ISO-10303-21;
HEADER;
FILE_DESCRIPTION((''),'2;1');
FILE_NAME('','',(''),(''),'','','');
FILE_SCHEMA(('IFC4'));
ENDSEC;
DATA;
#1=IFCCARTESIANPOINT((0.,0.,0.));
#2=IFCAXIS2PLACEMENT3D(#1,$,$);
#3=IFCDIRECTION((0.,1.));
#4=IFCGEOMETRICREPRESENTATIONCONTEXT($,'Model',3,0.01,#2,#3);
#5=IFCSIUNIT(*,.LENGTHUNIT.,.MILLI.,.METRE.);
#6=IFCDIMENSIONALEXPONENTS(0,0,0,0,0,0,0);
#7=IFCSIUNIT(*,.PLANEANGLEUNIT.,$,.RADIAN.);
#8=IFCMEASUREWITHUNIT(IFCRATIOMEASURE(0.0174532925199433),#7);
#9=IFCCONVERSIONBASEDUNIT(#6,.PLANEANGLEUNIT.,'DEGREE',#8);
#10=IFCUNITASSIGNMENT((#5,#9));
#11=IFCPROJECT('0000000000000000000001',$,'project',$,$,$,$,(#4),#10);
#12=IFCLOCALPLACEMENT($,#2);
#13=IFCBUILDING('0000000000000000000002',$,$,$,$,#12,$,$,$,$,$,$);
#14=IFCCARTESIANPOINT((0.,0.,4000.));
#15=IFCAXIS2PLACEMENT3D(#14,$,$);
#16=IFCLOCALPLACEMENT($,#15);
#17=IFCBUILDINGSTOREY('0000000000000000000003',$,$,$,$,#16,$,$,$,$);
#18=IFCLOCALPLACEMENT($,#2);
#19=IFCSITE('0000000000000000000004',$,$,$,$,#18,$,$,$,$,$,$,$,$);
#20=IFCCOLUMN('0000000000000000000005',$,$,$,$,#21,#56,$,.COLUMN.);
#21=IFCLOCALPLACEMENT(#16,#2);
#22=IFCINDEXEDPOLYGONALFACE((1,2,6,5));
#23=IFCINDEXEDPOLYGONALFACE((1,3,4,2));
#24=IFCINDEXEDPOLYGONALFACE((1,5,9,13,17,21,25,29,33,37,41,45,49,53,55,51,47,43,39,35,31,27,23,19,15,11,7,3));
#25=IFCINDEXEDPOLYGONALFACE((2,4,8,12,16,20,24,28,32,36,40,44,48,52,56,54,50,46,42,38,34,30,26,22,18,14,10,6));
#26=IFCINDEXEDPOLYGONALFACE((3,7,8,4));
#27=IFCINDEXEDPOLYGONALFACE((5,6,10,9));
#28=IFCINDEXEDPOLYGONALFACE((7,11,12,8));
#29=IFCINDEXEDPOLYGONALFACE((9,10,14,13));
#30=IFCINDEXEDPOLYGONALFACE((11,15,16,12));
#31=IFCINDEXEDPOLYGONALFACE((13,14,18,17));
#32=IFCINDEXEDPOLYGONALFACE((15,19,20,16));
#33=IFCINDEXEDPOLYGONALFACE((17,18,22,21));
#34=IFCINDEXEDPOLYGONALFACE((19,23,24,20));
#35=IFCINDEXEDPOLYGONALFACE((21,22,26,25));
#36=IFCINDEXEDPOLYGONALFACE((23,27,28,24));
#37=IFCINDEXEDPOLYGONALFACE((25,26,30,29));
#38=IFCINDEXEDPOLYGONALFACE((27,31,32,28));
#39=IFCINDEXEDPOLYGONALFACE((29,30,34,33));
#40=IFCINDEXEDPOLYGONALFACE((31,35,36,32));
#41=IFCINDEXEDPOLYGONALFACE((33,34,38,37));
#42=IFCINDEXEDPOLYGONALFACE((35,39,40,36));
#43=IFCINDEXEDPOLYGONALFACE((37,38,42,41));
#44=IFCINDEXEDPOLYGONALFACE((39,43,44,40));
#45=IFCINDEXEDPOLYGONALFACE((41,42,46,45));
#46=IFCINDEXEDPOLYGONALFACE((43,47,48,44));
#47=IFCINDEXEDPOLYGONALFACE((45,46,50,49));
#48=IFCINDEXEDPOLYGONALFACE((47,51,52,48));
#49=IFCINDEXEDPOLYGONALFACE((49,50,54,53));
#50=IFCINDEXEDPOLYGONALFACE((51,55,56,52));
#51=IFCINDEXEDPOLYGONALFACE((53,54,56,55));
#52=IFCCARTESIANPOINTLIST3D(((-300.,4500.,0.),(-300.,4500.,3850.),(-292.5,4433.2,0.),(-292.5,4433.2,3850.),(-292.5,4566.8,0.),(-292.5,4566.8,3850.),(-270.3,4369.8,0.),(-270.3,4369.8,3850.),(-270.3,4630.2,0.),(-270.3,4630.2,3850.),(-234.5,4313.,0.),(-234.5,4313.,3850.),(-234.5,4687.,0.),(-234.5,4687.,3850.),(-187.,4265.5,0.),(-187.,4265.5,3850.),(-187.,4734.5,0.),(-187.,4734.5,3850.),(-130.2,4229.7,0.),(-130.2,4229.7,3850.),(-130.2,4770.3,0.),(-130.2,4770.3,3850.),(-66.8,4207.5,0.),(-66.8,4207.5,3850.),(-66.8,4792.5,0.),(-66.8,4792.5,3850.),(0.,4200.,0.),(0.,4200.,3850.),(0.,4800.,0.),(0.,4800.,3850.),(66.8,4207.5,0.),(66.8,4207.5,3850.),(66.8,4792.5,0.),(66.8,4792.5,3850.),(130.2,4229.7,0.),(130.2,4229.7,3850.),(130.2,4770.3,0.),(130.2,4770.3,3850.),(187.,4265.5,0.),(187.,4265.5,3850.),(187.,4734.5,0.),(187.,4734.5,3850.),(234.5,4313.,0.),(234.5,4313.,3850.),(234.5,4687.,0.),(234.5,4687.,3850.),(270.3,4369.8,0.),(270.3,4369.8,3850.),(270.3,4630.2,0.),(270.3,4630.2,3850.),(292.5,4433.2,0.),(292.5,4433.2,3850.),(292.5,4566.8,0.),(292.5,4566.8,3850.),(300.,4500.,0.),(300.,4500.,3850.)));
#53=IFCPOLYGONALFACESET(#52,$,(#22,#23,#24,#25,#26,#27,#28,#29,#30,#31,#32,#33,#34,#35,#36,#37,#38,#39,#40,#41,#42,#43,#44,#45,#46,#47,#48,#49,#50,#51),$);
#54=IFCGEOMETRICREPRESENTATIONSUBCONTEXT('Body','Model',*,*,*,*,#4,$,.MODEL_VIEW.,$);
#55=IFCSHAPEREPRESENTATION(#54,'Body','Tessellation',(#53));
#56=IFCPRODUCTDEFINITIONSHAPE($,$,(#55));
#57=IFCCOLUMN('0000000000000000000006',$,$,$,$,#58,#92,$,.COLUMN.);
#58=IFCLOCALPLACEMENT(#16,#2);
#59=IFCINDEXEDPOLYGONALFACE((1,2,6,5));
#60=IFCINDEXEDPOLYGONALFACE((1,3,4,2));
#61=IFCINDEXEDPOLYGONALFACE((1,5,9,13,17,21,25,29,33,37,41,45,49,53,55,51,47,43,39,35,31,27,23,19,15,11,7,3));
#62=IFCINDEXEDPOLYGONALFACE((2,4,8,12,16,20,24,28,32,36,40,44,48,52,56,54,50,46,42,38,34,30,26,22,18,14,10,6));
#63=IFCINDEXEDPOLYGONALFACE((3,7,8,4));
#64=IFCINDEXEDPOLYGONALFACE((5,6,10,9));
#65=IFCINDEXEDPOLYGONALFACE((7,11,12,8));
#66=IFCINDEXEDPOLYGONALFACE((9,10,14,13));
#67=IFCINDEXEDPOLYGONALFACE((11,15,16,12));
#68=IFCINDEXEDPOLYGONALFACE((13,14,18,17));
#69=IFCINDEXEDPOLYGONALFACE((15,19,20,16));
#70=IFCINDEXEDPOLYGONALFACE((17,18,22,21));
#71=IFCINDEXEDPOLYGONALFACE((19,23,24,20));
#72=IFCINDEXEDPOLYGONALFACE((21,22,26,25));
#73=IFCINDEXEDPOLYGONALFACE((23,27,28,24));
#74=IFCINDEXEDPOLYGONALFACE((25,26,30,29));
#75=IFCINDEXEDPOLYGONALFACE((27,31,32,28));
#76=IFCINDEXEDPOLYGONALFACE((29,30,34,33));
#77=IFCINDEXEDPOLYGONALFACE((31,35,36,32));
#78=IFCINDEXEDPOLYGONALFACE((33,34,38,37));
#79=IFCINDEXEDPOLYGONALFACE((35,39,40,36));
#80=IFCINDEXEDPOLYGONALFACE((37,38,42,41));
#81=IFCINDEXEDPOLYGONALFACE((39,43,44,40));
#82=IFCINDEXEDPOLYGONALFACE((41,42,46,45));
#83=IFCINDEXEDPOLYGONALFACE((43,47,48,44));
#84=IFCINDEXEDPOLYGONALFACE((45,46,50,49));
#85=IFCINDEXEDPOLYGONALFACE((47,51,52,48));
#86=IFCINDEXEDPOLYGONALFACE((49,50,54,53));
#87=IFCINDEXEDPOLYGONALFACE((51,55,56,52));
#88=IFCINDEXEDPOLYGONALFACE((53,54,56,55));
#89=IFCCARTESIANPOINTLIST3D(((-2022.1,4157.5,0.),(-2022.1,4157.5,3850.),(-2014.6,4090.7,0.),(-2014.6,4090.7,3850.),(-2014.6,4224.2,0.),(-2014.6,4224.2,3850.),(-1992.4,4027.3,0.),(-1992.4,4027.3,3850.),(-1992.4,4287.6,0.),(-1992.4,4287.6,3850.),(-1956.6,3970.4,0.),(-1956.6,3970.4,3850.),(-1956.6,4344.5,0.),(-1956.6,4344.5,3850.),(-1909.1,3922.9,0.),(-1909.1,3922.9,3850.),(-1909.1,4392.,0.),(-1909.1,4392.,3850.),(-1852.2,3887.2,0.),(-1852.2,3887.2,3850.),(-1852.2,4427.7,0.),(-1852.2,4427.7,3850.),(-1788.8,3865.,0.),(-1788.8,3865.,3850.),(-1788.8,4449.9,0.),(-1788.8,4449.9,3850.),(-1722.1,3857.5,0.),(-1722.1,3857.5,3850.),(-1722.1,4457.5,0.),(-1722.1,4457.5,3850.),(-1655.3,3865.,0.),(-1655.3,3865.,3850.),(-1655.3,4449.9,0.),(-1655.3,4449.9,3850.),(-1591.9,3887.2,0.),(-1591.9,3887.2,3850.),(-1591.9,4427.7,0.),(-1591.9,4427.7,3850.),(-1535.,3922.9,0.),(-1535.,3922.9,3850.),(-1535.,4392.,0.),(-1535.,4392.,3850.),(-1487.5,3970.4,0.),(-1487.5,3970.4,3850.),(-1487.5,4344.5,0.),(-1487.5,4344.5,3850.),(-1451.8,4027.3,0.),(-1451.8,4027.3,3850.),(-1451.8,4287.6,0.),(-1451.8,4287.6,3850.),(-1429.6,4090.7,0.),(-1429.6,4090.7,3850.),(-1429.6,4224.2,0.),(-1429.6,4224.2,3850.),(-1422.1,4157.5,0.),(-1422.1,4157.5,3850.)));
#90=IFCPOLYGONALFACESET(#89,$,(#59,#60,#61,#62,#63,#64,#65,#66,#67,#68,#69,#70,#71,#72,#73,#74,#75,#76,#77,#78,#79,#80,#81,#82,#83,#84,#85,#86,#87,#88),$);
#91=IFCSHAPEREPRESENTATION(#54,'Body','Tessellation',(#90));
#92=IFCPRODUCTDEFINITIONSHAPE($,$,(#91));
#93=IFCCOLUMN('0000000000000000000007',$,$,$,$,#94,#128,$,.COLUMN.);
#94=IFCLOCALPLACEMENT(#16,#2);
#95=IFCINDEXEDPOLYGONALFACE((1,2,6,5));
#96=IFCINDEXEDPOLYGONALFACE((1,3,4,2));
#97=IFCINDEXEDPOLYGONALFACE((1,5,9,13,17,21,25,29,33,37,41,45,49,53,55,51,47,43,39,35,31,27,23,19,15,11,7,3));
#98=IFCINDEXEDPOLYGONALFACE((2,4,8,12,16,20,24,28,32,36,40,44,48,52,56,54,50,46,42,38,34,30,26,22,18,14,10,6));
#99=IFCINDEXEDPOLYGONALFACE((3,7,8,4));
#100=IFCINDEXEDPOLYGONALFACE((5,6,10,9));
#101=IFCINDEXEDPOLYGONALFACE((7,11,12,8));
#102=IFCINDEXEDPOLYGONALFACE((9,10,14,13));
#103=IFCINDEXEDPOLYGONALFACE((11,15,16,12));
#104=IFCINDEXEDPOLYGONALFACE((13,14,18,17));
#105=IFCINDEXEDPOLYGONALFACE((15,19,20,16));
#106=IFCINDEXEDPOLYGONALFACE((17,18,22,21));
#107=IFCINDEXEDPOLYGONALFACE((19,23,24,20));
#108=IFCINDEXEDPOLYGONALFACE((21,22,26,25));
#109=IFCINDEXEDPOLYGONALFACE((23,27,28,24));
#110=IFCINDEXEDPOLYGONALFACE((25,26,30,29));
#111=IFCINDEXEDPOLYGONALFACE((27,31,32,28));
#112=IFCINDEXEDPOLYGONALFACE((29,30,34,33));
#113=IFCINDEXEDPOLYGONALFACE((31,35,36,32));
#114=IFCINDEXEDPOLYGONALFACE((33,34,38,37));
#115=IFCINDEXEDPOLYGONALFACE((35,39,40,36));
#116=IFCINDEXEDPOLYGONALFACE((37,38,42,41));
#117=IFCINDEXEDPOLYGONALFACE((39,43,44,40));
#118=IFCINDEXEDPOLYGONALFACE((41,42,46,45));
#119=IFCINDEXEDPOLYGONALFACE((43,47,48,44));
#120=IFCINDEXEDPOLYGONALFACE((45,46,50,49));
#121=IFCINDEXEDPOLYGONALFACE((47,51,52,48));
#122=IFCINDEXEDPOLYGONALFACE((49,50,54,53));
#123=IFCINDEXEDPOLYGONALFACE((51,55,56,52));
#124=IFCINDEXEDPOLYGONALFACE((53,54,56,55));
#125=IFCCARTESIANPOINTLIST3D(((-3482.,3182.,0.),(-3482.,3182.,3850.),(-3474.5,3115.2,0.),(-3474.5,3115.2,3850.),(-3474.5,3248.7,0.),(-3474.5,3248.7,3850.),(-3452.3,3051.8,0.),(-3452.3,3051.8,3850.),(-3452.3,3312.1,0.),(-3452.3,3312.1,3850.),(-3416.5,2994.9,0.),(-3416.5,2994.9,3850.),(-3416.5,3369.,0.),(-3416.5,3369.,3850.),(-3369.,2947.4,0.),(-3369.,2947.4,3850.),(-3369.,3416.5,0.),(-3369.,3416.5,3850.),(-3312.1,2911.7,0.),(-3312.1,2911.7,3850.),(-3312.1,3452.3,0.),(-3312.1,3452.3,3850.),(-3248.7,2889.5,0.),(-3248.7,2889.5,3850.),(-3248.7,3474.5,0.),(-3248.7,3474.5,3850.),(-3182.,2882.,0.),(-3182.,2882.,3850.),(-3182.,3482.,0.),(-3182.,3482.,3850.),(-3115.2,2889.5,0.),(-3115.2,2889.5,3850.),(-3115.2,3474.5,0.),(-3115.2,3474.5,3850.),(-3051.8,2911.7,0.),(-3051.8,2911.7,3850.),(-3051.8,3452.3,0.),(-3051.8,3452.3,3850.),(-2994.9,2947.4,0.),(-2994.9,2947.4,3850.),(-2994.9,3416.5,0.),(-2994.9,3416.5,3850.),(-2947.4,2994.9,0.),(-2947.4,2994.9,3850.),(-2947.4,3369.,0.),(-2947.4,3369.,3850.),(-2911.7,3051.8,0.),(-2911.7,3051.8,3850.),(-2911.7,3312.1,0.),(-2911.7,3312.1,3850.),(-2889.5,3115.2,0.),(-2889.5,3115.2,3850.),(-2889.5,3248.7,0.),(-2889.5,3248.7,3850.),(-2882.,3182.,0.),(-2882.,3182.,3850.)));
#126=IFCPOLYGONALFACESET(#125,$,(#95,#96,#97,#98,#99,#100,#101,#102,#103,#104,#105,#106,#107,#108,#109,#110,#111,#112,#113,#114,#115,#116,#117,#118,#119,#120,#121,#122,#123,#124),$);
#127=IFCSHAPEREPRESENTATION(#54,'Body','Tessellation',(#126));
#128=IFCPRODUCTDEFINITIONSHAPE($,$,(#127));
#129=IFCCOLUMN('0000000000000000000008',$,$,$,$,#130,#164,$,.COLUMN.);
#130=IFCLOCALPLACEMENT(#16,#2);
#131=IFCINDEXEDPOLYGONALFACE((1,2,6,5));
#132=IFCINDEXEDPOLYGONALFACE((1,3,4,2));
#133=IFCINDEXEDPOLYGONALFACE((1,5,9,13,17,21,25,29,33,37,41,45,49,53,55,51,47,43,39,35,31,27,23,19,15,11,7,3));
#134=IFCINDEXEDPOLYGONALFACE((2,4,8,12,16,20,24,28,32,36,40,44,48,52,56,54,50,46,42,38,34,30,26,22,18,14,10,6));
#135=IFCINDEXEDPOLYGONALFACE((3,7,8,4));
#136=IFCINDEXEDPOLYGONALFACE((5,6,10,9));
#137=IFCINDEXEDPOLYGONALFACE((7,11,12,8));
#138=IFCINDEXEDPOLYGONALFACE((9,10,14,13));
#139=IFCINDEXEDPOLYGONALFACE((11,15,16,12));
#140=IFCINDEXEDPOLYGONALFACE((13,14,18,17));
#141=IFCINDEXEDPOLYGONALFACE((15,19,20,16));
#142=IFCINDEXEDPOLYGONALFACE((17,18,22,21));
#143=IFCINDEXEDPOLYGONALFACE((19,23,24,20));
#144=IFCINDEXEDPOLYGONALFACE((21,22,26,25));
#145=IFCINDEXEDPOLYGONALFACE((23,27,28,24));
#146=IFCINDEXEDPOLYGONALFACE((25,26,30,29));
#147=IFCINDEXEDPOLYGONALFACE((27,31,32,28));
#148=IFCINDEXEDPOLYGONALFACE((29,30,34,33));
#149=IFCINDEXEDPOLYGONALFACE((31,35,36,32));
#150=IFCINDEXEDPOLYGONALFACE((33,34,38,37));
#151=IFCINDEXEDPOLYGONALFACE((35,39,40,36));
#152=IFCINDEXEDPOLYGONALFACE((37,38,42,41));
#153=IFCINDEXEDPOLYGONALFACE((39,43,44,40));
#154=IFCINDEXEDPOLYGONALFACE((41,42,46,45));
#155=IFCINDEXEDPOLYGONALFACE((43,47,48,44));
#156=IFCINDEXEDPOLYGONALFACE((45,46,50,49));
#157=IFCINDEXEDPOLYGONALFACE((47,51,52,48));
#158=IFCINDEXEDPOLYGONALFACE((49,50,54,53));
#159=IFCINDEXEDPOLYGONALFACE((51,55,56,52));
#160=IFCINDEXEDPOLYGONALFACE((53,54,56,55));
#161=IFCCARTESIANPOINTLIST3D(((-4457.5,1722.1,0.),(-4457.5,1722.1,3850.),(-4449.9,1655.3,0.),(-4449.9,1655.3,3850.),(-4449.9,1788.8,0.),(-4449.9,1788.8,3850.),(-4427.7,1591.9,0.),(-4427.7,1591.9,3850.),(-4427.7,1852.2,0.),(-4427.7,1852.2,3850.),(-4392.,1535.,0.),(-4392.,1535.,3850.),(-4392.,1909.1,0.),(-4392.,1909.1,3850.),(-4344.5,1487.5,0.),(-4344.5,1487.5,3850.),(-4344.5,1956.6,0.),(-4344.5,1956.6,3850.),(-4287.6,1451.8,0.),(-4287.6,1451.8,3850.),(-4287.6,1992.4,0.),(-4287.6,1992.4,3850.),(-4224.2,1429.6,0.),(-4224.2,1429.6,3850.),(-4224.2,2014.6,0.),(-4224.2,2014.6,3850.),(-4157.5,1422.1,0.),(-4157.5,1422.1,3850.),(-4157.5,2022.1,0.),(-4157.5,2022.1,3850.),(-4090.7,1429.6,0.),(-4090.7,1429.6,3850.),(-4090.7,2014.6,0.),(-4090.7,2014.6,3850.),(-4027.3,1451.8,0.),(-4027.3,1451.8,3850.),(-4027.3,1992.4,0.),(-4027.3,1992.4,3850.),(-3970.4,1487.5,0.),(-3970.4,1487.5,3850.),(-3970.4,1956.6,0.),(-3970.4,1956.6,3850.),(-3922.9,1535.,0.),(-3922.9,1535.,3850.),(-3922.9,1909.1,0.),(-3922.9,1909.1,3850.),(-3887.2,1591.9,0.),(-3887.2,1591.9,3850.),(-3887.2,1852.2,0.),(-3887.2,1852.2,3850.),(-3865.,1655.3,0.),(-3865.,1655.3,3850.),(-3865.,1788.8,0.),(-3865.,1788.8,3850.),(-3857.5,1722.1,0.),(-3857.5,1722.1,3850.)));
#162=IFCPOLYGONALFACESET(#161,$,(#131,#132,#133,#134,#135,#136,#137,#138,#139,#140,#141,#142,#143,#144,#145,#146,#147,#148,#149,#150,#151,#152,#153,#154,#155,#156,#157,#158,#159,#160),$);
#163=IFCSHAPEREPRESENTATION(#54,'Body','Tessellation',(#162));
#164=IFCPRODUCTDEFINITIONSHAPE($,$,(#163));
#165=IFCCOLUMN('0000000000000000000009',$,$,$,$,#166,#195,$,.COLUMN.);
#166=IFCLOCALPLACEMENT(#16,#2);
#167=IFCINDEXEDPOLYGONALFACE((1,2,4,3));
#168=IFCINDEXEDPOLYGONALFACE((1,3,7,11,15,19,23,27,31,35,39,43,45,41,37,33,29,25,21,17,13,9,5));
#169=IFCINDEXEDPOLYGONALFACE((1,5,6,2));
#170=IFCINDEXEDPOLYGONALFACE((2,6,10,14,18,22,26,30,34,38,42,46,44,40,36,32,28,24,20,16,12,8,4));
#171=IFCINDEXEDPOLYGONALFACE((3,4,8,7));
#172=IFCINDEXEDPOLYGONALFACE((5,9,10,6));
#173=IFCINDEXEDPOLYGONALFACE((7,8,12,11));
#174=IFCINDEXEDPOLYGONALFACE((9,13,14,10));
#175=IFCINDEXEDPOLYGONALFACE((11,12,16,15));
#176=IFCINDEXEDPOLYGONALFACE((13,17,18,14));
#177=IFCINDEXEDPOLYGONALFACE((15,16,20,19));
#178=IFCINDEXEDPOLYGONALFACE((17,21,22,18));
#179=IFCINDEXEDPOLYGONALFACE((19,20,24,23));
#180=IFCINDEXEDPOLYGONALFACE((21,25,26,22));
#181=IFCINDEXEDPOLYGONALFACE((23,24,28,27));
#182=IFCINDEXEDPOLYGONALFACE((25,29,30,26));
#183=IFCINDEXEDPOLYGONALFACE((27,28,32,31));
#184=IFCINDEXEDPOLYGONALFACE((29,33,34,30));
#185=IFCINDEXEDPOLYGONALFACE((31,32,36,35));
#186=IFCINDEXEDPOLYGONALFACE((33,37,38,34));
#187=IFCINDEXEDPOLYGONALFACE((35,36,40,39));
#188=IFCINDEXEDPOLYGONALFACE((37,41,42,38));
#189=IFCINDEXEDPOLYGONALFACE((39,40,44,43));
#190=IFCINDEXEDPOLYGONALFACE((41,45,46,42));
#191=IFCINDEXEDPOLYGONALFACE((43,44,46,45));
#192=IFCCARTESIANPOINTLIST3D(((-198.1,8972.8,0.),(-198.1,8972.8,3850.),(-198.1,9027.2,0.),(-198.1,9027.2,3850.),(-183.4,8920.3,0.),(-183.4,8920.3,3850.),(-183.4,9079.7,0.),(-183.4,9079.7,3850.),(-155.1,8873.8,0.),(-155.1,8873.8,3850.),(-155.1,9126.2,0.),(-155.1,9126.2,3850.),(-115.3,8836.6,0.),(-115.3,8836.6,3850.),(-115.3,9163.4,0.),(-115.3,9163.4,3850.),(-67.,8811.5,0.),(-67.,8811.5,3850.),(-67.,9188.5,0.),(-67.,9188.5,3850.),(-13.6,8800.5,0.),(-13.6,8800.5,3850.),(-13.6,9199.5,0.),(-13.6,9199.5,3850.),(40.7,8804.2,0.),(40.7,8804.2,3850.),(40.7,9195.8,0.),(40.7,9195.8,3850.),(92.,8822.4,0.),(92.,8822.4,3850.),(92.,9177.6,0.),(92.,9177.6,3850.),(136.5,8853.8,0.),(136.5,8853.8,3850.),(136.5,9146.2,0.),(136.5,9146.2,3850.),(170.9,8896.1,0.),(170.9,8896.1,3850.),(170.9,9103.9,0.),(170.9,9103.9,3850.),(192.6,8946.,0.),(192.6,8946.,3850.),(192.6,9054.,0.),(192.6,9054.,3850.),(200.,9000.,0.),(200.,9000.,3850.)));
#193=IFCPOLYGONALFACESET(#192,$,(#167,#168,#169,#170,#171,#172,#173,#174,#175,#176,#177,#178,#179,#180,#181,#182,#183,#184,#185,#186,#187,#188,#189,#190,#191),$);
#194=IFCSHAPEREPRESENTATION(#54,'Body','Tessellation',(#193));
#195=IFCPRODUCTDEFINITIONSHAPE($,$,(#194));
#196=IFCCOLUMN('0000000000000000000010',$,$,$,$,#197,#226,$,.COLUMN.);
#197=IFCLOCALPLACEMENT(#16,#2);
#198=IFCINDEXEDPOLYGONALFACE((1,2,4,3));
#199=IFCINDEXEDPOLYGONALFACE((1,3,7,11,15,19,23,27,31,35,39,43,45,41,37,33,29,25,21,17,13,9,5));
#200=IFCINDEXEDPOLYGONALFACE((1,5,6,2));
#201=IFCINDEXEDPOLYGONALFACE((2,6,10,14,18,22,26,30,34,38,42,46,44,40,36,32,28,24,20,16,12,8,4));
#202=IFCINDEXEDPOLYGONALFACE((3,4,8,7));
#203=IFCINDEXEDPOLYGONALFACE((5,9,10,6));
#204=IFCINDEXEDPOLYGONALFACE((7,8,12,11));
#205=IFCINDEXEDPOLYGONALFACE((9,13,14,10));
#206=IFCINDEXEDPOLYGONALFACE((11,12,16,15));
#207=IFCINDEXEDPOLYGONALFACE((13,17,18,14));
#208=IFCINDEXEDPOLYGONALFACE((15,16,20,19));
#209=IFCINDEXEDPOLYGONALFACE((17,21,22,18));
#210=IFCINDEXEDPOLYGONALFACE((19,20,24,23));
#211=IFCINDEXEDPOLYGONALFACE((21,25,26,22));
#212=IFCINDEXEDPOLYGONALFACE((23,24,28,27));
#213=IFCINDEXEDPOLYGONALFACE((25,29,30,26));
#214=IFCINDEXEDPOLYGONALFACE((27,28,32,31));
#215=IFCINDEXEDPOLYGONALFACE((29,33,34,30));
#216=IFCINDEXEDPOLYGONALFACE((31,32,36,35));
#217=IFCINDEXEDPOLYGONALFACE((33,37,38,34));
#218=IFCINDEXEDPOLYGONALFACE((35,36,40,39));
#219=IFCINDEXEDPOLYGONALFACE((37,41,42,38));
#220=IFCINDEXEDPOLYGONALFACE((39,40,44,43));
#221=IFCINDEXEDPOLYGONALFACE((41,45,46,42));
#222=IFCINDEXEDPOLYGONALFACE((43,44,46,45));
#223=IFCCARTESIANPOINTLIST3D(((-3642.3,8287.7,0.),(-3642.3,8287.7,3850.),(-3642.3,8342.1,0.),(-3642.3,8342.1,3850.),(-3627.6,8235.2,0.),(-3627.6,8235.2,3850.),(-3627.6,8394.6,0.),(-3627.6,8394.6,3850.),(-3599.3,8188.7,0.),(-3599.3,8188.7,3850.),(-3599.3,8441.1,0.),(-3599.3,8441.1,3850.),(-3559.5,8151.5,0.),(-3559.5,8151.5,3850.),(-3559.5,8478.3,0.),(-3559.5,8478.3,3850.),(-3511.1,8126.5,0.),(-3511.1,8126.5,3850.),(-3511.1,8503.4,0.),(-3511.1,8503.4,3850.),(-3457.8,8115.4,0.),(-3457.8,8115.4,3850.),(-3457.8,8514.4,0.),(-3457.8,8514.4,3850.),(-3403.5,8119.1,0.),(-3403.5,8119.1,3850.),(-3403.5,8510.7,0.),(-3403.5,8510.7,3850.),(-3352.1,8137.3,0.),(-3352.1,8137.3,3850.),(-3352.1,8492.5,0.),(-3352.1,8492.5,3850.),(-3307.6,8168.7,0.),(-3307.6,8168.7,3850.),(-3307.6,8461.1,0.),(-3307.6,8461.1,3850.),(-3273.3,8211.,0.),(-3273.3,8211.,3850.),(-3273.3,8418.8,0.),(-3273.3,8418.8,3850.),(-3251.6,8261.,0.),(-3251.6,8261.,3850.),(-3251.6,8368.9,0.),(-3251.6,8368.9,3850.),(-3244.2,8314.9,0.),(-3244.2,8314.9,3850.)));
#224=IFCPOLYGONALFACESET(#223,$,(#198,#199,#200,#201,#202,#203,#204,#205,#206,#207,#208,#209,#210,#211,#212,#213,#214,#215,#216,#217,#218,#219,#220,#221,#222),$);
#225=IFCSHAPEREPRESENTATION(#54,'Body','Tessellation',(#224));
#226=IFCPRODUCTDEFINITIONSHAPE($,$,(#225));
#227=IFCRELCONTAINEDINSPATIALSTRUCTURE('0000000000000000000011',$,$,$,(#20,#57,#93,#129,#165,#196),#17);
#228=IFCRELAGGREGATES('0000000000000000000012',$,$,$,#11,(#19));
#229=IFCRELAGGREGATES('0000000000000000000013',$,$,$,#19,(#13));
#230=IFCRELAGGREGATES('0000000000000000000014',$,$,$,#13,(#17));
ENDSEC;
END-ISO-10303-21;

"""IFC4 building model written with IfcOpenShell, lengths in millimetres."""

from ifc_helpers import new_model, entity, si_unit, converted_unit, direction, frame, origin, origin_2d, place, context, subcontext, project, spatial, circle, extrude, element, save


model = new_model("IFC4")

# Units and contexts
model_context = context("Model", 3, precision=0.01, world=origin(), true_north=direction((0.0, 1.0)))
body_context = subcontext(model_context, "Body", "Model", "MODEL_VIEW")
ifc_project = project(units=[si_unit("LENGTHUNIT", "METRE", prefix="MILLI"), converted_unit("PLANEANGLEUNIT", "DEGREE", entity("IfcRatioMeasure", 0.0174532925199433), si_unit("PLANEANGLEUNIT", "RADIAN"), dimensions=[0, 0, 0, 0, 0, 0, 0])], contexts=[model_context])

# Site, building, storey
site_placement = place(None, origin())
site = spatial("IfcSite", under=ifc_project, at=site_placement)
building_placement = place(None, origin())
building = spatial("IfcBuilding", under=site, at=building_placement)
storey_placement = place(None, frame((0.0, 0.0, 4000.0)))
storey = spatial("IfcBuildingStorey", under=building, at=storey_placement)

# Columns
for number, where in (
    (1, (0.0, 4500.0, 0.0)),
    (2, (-1722.1, 4157.5, 0.0)),
    (3, (-3182.0, 3182.0, 0.0)),
    (4, (-4157.5, 1722.1, 0.0)),
):
    element("IfcColumn", number, at=place(storey_placement, frame(where)), inside=storey, PredefinedType="COLUMN", context=body_context, shape_type="SweptSolid", body=[
        extrude(circle(Radius=300.0, at=origin_2d()), origin(), (0.0, 0.0, 1.0), 3850.0),
    ])
for number, where in (
    (5, (0.0, 9000.0, 0.0)),
    (6, (-3444.2, 8314.9, 0.0)),
):
    element("IfcColumn", number, at=place(storey_placement, frame(where)), inside=storey, PredefinedType="COLUMN", context=body_context, shape_type="SweptSolid", body=[
        extrude(circle(Radius=200.0, at=origin_2d()), origin(), (0.0, 0.0, 1.0), 3850.0),
    ])

save(model, "model.ifc")
